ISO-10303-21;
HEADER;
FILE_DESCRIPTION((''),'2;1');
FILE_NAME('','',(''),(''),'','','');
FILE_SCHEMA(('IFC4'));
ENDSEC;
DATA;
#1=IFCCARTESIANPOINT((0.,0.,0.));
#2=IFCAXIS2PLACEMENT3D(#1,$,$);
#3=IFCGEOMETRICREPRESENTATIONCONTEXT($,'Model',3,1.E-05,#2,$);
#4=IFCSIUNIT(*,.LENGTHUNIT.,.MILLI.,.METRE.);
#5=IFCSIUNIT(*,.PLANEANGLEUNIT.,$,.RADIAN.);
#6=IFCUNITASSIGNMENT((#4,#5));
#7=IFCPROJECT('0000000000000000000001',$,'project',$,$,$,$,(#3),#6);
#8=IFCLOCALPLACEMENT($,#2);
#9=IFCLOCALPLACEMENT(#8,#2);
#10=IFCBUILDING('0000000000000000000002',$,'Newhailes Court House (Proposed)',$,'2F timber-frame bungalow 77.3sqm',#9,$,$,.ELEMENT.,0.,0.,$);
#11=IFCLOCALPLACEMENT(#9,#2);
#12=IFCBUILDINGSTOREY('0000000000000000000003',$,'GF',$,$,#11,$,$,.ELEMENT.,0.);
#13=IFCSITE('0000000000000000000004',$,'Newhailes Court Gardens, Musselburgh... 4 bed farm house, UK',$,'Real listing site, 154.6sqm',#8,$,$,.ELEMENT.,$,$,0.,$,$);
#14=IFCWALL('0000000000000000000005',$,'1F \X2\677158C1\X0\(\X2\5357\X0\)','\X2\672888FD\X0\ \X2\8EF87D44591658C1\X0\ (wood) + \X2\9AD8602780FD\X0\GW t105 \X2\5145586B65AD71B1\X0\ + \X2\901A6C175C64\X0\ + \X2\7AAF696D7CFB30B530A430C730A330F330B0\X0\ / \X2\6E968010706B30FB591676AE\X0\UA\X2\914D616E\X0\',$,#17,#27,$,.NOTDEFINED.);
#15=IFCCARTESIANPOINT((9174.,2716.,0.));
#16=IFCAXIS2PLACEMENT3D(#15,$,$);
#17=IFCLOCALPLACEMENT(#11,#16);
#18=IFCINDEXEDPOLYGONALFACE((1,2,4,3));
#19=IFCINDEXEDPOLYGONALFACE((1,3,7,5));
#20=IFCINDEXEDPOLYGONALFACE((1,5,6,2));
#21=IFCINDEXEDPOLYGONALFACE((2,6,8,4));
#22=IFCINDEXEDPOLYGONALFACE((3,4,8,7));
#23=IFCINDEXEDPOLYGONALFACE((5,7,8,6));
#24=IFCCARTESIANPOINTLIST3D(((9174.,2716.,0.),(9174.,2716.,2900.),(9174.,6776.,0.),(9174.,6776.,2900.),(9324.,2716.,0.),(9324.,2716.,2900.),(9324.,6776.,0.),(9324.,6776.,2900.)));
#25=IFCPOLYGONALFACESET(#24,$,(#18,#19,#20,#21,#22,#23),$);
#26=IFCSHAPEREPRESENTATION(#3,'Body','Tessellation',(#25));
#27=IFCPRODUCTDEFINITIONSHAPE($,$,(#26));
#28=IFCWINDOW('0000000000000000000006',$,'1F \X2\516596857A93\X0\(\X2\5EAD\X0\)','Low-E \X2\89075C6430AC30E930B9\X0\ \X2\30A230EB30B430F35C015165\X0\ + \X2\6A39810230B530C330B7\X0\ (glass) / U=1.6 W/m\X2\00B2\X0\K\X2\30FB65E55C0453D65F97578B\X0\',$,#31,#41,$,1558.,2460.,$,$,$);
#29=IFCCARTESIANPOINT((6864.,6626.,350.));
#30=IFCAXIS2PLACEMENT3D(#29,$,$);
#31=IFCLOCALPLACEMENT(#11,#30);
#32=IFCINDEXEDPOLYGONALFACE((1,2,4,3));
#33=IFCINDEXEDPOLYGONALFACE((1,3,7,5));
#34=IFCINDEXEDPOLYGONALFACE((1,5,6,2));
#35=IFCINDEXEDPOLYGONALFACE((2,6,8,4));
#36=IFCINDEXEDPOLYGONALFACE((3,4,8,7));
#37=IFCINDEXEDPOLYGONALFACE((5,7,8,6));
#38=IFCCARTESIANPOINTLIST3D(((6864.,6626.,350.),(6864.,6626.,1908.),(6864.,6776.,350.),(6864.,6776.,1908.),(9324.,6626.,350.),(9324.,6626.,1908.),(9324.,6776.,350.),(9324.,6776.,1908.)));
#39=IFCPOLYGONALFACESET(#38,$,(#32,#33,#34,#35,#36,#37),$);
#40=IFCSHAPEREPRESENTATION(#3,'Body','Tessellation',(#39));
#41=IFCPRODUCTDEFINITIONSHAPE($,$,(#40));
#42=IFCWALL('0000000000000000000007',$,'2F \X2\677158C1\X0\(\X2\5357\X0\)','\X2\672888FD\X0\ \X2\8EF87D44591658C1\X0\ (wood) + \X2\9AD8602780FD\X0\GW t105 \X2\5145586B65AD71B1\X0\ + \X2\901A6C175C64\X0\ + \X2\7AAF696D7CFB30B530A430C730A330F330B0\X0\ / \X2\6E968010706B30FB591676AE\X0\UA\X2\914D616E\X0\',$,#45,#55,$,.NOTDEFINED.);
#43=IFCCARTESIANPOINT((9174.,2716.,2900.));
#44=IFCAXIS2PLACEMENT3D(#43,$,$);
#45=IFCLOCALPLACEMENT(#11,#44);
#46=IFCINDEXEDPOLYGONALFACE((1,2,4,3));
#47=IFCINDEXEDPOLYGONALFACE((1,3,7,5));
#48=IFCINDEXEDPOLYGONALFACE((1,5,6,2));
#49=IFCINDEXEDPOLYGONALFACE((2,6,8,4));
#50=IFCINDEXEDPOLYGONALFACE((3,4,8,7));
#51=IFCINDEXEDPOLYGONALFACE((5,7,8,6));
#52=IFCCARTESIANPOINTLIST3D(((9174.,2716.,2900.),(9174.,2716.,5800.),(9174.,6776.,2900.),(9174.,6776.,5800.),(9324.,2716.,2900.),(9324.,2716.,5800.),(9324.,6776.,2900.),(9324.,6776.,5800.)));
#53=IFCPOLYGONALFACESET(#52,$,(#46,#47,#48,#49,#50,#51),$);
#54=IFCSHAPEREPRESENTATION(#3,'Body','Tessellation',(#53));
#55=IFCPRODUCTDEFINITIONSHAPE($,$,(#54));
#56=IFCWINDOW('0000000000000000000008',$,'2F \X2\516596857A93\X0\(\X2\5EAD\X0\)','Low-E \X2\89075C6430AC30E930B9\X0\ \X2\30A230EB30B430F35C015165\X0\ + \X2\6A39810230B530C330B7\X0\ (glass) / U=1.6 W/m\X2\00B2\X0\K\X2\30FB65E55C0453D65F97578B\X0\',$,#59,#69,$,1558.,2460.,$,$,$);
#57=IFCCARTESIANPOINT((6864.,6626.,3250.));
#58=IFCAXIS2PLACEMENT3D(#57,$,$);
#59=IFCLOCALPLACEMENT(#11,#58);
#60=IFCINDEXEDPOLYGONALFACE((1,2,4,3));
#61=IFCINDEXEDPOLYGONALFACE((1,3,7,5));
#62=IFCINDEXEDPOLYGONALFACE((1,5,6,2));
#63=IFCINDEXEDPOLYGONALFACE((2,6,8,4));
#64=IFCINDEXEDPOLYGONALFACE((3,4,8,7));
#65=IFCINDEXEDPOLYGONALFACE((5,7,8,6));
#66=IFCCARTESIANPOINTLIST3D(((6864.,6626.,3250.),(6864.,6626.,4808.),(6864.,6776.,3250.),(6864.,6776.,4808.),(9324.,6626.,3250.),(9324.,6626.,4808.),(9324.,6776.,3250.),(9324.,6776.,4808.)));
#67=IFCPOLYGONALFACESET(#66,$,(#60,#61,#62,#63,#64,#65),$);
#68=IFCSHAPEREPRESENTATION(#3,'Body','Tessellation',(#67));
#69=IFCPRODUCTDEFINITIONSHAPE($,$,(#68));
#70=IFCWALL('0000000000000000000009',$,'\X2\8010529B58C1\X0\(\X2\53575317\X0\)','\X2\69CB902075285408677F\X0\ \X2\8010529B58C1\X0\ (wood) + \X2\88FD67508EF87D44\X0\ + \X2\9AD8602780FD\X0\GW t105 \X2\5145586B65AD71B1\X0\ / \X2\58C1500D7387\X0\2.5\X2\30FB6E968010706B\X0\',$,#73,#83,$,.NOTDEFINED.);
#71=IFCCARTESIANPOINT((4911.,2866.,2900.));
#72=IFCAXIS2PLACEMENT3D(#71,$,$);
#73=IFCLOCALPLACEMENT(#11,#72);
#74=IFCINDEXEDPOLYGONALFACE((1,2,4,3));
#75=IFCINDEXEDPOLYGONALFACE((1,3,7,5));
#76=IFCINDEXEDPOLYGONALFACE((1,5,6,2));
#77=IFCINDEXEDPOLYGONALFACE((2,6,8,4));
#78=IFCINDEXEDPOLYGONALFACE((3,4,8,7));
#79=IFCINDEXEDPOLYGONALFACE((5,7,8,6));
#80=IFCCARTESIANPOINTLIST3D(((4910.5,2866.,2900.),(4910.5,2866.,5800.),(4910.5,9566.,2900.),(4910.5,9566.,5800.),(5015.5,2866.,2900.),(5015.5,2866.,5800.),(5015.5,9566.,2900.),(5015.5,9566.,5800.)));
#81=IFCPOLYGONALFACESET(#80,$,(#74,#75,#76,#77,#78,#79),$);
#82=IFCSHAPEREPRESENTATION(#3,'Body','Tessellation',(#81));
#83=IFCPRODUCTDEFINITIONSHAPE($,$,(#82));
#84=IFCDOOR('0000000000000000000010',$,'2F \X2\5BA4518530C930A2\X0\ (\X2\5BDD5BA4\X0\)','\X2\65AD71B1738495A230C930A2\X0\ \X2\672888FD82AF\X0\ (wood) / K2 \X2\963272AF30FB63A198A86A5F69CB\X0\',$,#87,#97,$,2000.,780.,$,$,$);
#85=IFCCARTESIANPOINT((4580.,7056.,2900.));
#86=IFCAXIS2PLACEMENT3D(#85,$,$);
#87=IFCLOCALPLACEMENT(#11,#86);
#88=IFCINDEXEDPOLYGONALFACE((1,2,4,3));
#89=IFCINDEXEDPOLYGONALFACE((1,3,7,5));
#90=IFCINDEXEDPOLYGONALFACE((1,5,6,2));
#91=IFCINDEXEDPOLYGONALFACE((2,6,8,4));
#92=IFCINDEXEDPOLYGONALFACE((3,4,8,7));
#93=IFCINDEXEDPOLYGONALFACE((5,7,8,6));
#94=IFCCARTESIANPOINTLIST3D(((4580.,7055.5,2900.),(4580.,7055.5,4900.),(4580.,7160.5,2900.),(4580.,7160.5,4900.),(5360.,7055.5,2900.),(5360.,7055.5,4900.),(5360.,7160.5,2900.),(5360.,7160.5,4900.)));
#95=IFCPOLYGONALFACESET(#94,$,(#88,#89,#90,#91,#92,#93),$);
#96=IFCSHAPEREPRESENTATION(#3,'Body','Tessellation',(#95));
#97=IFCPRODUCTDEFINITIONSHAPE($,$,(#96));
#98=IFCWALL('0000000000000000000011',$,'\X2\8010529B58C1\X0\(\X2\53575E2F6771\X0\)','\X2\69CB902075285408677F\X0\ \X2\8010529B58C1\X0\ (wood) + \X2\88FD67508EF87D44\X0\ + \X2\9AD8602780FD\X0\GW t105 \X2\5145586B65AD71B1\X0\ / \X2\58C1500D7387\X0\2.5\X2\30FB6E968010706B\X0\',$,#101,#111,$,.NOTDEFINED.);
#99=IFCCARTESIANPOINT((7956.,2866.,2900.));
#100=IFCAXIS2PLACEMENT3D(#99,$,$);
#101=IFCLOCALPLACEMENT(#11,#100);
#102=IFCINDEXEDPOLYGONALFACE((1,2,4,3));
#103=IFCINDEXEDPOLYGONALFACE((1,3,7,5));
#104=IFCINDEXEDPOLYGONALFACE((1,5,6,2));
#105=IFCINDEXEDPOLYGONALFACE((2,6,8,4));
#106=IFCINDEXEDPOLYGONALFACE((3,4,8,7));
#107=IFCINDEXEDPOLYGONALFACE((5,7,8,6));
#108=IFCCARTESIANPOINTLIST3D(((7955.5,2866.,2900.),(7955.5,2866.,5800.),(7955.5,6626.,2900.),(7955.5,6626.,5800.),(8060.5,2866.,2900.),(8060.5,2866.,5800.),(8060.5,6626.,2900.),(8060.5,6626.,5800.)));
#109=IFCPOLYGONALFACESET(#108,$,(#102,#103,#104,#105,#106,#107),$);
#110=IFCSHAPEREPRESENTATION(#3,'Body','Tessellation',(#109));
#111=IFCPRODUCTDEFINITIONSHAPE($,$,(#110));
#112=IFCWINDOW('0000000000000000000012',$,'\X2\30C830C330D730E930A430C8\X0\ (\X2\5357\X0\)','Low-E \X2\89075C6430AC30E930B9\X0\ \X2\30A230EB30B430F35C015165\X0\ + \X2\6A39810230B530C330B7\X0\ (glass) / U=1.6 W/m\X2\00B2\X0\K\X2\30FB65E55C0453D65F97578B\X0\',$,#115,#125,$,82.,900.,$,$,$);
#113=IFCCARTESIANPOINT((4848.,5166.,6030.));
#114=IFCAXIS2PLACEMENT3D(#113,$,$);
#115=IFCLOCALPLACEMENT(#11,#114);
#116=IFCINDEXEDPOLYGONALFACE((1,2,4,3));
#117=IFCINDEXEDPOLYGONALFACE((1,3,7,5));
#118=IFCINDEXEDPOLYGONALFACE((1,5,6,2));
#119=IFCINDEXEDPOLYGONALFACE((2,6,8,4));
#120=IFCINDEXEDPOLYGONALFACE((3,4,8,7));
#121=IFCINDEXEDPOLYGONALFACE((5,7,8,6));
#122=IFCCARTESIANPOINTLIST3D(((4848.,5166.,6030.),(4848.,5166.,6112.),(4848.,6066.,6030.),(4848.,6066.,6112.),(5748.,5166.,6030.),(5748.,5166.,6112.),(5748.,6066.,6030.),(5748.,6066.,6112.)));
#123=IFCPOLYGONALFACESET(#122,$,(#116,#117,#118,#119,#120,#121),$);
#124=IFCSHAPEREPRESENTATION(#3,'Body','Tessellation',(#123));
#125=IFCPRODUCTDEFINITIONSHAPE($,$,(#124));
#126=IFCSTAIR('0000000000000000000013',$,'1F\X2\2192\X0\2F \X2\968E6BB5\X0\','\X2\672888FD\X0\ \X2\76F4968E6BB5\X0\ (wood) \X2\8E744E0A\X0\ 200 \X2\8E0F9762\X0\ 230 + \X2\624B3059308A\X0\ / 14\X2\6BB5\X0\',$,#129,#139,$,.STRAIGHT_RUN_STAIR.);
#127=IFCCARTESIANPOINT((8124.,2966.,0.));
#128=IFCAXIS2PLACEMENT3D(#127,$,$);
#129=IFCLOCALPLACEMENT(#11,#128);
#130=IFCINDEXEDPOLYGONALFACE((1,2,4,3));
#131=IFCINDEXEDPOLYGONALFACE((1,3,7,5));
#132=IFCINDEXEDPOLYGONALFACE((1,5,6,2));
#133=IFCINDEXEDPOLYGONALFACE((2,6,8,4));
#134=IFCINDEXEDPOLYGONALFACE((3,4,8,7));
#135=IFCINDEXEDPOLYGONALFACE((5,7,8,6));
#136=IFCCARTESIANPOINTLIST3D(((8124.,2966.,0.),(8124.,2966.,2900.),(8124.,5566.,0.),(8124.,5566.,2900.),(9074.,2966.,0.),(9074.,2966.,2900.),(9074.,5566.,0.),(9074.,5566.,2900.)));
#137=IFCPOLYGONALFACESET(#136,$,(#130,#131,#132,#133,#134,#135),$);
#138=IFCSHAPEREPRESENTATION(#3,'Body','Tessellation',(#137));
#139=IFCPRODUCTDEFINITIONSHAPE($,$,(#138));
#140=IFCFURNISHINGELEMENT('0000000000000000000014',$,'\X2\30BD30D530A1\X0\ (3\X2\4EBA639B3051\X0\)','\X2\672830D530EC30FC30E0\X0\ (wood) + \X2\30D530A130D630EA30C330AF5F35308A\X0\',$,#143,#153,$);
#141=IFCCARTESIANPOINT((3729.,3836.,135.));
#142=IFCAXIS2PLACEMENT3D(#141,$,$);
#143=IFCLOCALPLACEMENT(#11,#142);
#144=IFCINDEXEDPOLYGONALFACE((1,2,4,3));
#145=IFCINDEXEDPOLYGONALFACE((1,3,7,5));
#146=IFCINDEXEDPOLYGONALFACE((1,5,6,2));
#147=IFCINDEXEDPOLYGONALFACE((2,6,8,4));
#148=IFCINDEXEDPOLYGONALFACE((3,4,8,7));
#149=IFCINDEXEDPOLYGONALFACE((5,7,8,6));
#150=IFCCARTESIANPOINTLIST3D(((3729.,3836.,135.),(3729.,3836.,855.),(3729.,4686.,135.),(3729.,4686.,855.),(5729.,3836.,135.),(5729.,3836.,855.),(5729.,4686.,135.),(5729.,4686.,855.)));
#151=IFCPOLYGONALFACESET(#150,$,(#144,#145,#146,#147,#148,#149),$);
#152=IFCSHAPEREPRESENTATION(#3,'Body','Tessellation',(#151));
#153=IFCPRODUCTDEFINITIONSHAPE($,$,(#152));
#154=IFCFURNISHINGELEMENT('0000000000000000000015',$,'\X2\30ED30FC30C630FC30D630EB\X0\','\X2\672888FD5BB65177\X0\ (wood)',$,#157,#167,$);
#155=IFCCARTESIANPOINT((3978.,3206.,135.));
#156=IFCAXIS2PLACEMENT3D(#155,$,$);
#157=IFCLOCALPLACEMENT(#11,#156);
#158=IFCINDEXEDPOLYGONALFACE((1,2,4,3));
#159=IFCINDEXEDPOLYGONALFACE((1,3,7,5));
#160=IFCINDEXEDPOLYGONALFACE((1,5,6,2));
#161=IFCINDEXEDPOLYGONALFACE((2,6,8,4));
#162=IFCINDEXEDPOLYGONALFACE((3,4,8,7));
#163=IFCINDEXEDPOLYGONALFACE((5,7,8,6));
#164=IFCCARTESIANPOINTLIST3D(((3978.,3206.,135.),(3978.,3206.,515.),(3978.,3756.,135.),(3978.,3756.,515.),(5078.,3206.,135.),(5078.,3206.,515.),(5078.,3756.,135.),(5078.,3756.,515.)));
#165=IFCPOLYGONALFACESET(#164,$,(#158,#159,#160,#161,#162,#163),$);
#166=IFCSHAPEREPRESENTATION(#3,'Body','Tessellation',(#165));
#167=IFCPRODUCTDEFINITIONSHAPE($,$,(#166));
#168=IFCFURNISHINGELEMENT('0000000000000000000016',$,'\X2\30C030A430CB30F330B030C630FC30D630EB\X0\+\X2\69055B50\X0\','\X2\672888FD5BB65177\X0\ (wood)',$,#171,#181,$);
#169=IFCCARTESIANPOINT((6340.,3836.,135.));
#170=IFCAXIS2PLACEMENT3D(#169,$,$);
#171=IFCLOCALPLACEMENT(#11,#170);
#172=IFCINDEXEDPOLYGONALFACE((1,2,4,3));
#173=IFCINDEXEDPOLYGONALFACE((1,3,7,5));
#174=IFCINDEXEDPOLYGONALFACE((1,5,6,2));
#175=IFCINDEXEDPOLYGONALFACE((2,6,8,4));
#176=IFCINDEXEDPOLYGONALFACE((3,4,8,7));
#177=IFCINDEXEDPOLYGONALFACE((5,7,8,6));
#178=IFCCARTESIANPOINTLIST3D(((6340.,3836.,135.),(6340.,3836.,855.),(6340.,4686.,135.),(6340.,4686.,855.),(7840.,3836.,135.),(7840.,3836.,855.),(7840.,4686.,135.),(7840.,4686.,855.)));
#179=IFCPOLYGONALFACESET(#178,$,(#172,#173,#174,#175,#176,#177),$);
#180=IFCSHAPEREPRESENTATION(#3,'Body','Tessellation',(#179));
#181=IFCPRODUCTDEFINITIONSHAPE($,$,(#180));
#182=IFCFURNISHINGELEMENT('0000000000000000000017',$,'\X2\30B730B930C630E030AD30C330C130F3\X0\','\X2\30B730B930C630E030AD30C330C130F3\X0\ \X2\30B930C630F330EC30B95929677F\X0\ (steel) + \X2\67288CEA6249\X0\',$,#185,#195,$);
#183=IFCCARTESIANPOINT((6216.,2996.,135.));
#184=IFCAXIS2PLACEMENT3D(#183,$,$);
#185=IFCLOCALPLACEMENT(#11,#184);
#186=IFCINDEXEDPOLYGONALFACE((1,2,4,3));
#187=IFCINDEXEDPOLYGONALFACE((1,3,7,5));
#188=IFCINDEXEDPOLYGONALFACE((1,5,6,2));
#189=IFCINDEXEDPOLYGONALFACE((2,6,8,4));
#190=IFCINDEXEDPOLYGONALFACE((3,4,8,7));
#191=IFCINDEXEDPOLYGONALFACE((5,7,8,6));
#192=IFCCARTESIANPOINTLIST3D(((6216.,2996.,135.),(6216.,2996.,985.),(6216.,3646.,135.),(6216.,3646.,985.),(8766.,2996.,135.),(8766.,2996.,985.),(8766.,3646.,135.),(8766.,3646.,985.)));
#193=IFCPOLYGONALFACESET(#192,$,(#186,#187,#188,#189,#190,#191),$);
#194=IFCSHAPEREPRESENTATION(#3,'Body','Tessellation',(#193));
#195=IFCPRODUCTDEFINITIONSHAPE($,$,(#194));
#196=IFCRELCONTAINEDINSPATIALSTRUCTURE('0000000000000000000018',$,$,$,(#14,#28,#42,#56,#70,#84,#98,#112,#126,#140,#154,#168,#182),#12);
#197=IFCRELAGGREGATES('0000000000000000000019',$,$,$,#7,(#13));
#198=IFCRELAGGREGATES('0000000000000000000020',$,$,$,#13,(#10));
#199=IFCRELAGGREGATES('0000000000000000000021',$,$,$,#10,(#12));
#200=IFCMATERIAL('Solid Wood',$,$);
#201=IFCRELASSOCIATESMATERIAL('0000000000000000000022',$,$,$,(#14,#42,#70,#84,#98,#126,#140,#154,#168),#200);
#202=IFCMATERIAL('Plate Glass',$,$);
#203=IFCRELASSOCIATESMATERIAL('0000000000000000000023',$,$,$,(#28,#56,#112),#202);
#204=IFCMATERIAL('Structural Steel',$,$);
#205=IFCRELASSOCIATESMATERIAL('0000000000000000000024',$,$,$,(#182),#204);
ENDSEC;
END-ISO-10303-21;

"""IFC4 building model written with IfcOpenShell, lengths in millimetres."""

from ifc_helpers import new_model, si_unit, frame, frame_2d, origin, place, context, project, spatial, rectangle, extrude, material, element, fill, save


model = new_model("IFC4")

# Units and contexts
model_context = context("Model", 3, precision=1e-05, world=origin())
ifc_project = project(units=[si_unit("LENGTHUNIT", "METRE", prefix="MILLI"), si_unit("PLANEANGLEUNIT", "RADIAN")], contexts=[model_context])

# Site, building, storey
site_placement = place(None, origin())
site = spatial("IfcSite", under=ifc_project, at=site_placement, Name="Newhailes Court Gardens, Musselburgh... 4 bed farm house, UK", ObjectType="Real listing site, 154.6sqm", CompositionType="ELEMENT", RefElevation=0.0)
building_placement = place(site_placement, origin())
building = spatial("IfcBuilding", under=site, at=building_placement, Name="Newhailes Court House (Proposed)", ObjectType="2F timber-frame bungalow 77.3sqm", CompositionType="ELEMENT", ElevationOfRefHeight=0.0, ElevationOfTerrain=0.0)
storey_placement = place(building_placement, origin())
storey = spatial("IfcBuildingStorey", under=building, at=storey_placement, Name="GF", CompositionType="ELEMENT", Elevation=0.0)

# Wall, opening, window
ifc_material_1 = material(Name="Solid Wood")
wall_1_placement = place(storey_placement, frame((9174.0, 2716.0, 0.0)))
wall_1 = element("IfcWall", 1, at=wall_1_placement, inside=storey, material=ifc_material_1, Name="1F 東壁(南)", Description="木製 軸組外壁 (wood) + 高性能GW t105 充填断熱 + 通気層 + 窯業系サイディング / 準耐火・外皮UA配慮", PredefinedType="NOTDEFINED", context=model_context, shape_type="SweptSolid", body=[
    extrude(rectangle(XDim=150.0, YDim=4060.0, at=frame_2d((75.0, 2030.0))), frame((9174.0, 2716.0, 0.0)), (0.0, 0.0, 1.0), 2900.0),
])
opening_1_placement = place(storey_placement, frame((6864.0, 6626.0, 350.0)))
opening_1 = element("IfcOpeningElement", 2, at=opening_1_placement, cuts=wall_1, PredefinedType="NOTDEFINED", context=model_context, shape_type="SweptSolid", body=[
    extrude(rectangle(XDim=2460.0, YDim=150.0, at=frame_2d((1230.0, 75.0))), frame((6864.0, 6626.0, 350.0)), (0.0, 0.0, 1.0), 1558.0),
])
ifc_material_2 = material(Name="Plate Glass")
window_1_placement = place(storey_placement, frame((6864.0, 6626.0, 350.0)))
window_1 = element("IfcWindow", 3, at=window_1_placement, inside=storey, material=ifc_material_2, Name="1F 入隅窓(庭)", Description="Low-E 複層ガラス アルゴン封入 + 樹脂サッシ (glass) / U=1.6 W/m²K・日射取得型", OverallHeight=1558.0, OverallWidth=2460.0, context=model_context, shape_type="SweptSolid", body=[
    extrude(rectangle(XDim=2460.0, YDim=150.0, at=frame_2d((1230.0, 75.0))), frame((6864.0, 6626.0, 350.0)), (0.0, 0.0, 1.0), 1558.0),
])
fill(opening_1, window_1)

# Wall, opening, window
wall_2_placement = place(storey_placement, frame((9174.0, 2716.0, 2900.0)))
wall_2 = element("IfcWall", 4, at=wall_2_placement, inside=storey, material=ifc_material_1, Name="2F 東壁(南)", Description="木製 軸組外壁 (wood) + 高性能GW t105 充填断熱 + 通気層 + 窯業系サイディング / 準耐火・外皮UA配慮", PredefinedType="NOTDEFINED", context=model_context, shape_type="SweptSolid", body=[
    extrude(rectangle(XDim=150.0, YDim=4060.0, at=frame_2d((75.0, 2030.0))), frame((9174.0, 2716.0, 2900.0)), (0.0, 0.0, 1.0), 2900.0),
])
opening_2_placement = place(storey_placement, frame((6864.0, 6626.0, 3250.0)))
opening_2 = element("IfcOpeningElement", 5, at=opening_2_placement, cuts=wall_2, PredefinedType="NOTDEFINED", context=model_context, shape_type="SweptSolid", body=[
    extrude(rectangle(XDim=2460.0, YDim=150.0, at=frame_2d((1230.0, 75.0))), frame((6864.0, 6626.0, 3250.0)), (0.0, 0.0, 1.0), 1558.0),
])
window_2_placement = place(storey_placement, frame((6864.0, 6626.0, 3250.0)))
window_2 = element("IfcWindow", 6, at=window_2_placement, inside=storey, material=ifc_material_2, Name="2F 入隅窓(庭)", Description="Low-E 複層ガラス アルゴン封入 + 樹脂サッシ (glass) / U=1.6 W/m²K・日射取得型", OverallHeight=1558.0, OverallWidth=2460.0, context=model_context, shape_type="SweptSolid", body=[
    extrude(rectangle(XDim=2460.0, YDim=150.0, at=frame_2d((1230.0, 75.0))), frame((6864.0, 6626.0, 3250.0)), (0.0, 0.0, 1.0), 1558.0),
])
fill(opening_2, window_2)

# Wall, opening, door
wall_3_placement = place(storey_placement, frame((4911.0, 2866.0, 2900.0)))
wall_3 = element("IfcWall", 7, at=wall_3_placement, inside=storey, material=ifc_material_1, Name="耐力壁(南北)", Description="構造用合板 耐力壁 (wood) + 製材軸組 + 高性能GW t105 充填断熱 / 壁倍率2.5・準耐火", PredefinedType="NOTDEFINED", context=model_context, shape_type="SweptSolid", body=[
    extrude(rectangle(XDim=105.0, YDim=6700.0, at=frame_2d((52.0, 3350.0))), frame((4911.0, 2866.0, 2900.0)), (0.0, 0.0, 1.0), 2900.0),
])
opening_3_placement = place(storey_placement, frame((4580.0, 7056.0, 2900.0)))
opening_3 = element("IfcOpeningElement", 8, at=opening_3_placement, cuts=wall_3, PredefinedType="NOTDEFINED", context=model_context, shape_type="SweptSolid", body=[
    extrude(rectangle(XDim=780.0, YDim=105.0, at=frame_2d((390.0, 52.0))), frame((4580.0, 7056.0, 2900.0)), (0.0, 0.0, 1.0), 2000.0),
])
door_1_placement = place(storey_placement, frame((4580.0, 7056.0, 2900.0)))
door_1 = element("IfcDoor", 9, at=door_1_placement, inside=storey, material=ifc_material_1, Name="2F 室内ドア (寝室)", Description="断熱玄関ドア 木製芯 (wood) / K2 防犯・採風機構", OverallHeight=2000.0, OverallWidth=780.0, context=model_context, shape_type="SweptSolid", body=[
    extrude(rectangle(XDim=780.0, YDim=105.0, at=frame_2d((390.0, 52.0))), frame((4580.0, 7056.0, 2900.0)), (0.0, 0.0, 1.0), 2000.0),
])
fill(opening_3, door_1)

# Wall
wall_4_placement = place(storey_placement, frame((7956.0, 2866.0, 2900.0)))
element("IfcWall", 10, at=wall_4_placement, inside=storey, material=ifc_material_1, Name="耐力壁(南帯東)", Description="構造用合板 耐力壁 (wood) + 製材軸組 + 高性能GW t105 充填断熱 / 壁倍率2.5・準耐火", PredefinedType="NOTDEFINED", context=model_context, shape_type="SweptSolid", body=[
    extrude(rectangle(XDim=105.0, YDim=3760.0, at=frame_2d((52.0, 1880.0))), frame((7956.0, 2866.0, 2900.0)), (0.0, 0.0, 1.0), 2900.0),
])

# Window
window_3_placement = place(storey_placement, frame((4848.0, 5166.0, 6030.0)))
element("IfcWindow", 11, at=window_3_placement, inside=storey, material=ifc_material_2, Name="トップライト (南)", Description="Low-E 複層ガラス アルゴン封入 + 樹脂サッシ (glass) / U=1.6 W/m²K・日射取得型", OverallHeight=82.0, OverallWidth=900.0, context=model_context, shape_type="SweptSolid", body=[
    extrude(rectangle(XDim=900.0, YDim=900.0, at=frame_2d((450.0, 450.0))), frame((4848.0, 5166.0, 6030.0)), (0.0, 0.0, 1.0), 82.0),
])

# Stair
stair_placement = place(storey_placement, frame((8124.0, 2966.0, 0.0)))
element("IfcStair", 12, at=stair_placement, inside=storey, material=ifc_material_1, Name="1F→2F 階段", Description="木製 直階段 (wood) 蹴上 200 踏面 230 + 手すり / 14段", PredefinedType="STRAIGHT_RUN_STAIR", context=model_context, shape_type="SweptSolid", body=[
    extrude(rectangle(XDim=950.0, YDim=2600.0, at=frame_2d((475.0, 1300.0))), frame((8124.0, 2966.0, 0.0)), (0.0, 0.0, 1.0), 2900.0),
])

# Furnishing elements
furnishing_1_placement = place(storey_placement, frame((3729.0, 3836.0, 135.0)))
element("IfcFurnishingElement", 13, at=furnishing_1_placement, inside=storey, material=ifc_material_1, Name="ソファ (3人掛け)", Description="木フレーム (wood) + ファブリック張り", context=model_context, shape_type="SweptSolid", body=[
    extrude(rectangle(XDim=2000.0, YDim=850.0, at=frame_2d((1000.0, 425.0))), frame((3729.0, 3836.0, 135.0)), (0.0, 0.0, 1.0), 720.0),
])
furnishing_2_placement = place(storey_placement, frame((3978.0, 3206.0, 135.0)))
element("IfcFurnishingElement", 14, at=furnishing_2_placement, inside=storey, material=ifc_material_1, Name="ローテーブル", Description="木製家具 (wood)", context=model_context, shape_type="SweptSolid", body=[
    extrude(rectangle(XDim=1100.0, YDim=550.0, at=frame_2d((550.0, 275.0))), frame((3978.0, 3206.0, 135.0)), (0.0, 0.0, 1.0), 380.0),
])
furnishing_3_placement = place(storey_placement, frame((6340.0, 3836.0, 135.0)))
element("IfcFurnishingElement", 15, at=furnishing_3_placement, inside=storey, material=ifc_material_1, Name="ダイニングテーブル+椅子", Description="木製家具 (wood)", context=model_context, shape_type="SweptSolid", body=[
    extrude(rectangle(XDim=1500.0, YDim=850.0, at=frame_2d((750.0, 425.0))), frame((6340.0, 3836.0, 135.0)), (0.0, 0.0, 1.0), 720.0),
])
ifc_material_3 = material(Name="Structural Steel")
furnishing_4_placement = place(storey_placement, frame((6216.0, 2996.0, 135.0)))
element("IfcFurnishingElement", 16, at=furnishing_4_placement, inside=storey, material=ifc_material_3, Name="システムキッチン", Description="システムキッチン ステンレス天板 (steel) + 木質扉", context=model_context, shape_type="SweptSolid", body=[
    extrude(rectangle(XDim=2550.0, YDim=650.0, at=frame_2d((1275.0, 325.0))), frame((6216.0, 2996.0, 135.0)), (0.0, 0.0, 1.0), 850.0),
])

save(model, "model.ifc")
